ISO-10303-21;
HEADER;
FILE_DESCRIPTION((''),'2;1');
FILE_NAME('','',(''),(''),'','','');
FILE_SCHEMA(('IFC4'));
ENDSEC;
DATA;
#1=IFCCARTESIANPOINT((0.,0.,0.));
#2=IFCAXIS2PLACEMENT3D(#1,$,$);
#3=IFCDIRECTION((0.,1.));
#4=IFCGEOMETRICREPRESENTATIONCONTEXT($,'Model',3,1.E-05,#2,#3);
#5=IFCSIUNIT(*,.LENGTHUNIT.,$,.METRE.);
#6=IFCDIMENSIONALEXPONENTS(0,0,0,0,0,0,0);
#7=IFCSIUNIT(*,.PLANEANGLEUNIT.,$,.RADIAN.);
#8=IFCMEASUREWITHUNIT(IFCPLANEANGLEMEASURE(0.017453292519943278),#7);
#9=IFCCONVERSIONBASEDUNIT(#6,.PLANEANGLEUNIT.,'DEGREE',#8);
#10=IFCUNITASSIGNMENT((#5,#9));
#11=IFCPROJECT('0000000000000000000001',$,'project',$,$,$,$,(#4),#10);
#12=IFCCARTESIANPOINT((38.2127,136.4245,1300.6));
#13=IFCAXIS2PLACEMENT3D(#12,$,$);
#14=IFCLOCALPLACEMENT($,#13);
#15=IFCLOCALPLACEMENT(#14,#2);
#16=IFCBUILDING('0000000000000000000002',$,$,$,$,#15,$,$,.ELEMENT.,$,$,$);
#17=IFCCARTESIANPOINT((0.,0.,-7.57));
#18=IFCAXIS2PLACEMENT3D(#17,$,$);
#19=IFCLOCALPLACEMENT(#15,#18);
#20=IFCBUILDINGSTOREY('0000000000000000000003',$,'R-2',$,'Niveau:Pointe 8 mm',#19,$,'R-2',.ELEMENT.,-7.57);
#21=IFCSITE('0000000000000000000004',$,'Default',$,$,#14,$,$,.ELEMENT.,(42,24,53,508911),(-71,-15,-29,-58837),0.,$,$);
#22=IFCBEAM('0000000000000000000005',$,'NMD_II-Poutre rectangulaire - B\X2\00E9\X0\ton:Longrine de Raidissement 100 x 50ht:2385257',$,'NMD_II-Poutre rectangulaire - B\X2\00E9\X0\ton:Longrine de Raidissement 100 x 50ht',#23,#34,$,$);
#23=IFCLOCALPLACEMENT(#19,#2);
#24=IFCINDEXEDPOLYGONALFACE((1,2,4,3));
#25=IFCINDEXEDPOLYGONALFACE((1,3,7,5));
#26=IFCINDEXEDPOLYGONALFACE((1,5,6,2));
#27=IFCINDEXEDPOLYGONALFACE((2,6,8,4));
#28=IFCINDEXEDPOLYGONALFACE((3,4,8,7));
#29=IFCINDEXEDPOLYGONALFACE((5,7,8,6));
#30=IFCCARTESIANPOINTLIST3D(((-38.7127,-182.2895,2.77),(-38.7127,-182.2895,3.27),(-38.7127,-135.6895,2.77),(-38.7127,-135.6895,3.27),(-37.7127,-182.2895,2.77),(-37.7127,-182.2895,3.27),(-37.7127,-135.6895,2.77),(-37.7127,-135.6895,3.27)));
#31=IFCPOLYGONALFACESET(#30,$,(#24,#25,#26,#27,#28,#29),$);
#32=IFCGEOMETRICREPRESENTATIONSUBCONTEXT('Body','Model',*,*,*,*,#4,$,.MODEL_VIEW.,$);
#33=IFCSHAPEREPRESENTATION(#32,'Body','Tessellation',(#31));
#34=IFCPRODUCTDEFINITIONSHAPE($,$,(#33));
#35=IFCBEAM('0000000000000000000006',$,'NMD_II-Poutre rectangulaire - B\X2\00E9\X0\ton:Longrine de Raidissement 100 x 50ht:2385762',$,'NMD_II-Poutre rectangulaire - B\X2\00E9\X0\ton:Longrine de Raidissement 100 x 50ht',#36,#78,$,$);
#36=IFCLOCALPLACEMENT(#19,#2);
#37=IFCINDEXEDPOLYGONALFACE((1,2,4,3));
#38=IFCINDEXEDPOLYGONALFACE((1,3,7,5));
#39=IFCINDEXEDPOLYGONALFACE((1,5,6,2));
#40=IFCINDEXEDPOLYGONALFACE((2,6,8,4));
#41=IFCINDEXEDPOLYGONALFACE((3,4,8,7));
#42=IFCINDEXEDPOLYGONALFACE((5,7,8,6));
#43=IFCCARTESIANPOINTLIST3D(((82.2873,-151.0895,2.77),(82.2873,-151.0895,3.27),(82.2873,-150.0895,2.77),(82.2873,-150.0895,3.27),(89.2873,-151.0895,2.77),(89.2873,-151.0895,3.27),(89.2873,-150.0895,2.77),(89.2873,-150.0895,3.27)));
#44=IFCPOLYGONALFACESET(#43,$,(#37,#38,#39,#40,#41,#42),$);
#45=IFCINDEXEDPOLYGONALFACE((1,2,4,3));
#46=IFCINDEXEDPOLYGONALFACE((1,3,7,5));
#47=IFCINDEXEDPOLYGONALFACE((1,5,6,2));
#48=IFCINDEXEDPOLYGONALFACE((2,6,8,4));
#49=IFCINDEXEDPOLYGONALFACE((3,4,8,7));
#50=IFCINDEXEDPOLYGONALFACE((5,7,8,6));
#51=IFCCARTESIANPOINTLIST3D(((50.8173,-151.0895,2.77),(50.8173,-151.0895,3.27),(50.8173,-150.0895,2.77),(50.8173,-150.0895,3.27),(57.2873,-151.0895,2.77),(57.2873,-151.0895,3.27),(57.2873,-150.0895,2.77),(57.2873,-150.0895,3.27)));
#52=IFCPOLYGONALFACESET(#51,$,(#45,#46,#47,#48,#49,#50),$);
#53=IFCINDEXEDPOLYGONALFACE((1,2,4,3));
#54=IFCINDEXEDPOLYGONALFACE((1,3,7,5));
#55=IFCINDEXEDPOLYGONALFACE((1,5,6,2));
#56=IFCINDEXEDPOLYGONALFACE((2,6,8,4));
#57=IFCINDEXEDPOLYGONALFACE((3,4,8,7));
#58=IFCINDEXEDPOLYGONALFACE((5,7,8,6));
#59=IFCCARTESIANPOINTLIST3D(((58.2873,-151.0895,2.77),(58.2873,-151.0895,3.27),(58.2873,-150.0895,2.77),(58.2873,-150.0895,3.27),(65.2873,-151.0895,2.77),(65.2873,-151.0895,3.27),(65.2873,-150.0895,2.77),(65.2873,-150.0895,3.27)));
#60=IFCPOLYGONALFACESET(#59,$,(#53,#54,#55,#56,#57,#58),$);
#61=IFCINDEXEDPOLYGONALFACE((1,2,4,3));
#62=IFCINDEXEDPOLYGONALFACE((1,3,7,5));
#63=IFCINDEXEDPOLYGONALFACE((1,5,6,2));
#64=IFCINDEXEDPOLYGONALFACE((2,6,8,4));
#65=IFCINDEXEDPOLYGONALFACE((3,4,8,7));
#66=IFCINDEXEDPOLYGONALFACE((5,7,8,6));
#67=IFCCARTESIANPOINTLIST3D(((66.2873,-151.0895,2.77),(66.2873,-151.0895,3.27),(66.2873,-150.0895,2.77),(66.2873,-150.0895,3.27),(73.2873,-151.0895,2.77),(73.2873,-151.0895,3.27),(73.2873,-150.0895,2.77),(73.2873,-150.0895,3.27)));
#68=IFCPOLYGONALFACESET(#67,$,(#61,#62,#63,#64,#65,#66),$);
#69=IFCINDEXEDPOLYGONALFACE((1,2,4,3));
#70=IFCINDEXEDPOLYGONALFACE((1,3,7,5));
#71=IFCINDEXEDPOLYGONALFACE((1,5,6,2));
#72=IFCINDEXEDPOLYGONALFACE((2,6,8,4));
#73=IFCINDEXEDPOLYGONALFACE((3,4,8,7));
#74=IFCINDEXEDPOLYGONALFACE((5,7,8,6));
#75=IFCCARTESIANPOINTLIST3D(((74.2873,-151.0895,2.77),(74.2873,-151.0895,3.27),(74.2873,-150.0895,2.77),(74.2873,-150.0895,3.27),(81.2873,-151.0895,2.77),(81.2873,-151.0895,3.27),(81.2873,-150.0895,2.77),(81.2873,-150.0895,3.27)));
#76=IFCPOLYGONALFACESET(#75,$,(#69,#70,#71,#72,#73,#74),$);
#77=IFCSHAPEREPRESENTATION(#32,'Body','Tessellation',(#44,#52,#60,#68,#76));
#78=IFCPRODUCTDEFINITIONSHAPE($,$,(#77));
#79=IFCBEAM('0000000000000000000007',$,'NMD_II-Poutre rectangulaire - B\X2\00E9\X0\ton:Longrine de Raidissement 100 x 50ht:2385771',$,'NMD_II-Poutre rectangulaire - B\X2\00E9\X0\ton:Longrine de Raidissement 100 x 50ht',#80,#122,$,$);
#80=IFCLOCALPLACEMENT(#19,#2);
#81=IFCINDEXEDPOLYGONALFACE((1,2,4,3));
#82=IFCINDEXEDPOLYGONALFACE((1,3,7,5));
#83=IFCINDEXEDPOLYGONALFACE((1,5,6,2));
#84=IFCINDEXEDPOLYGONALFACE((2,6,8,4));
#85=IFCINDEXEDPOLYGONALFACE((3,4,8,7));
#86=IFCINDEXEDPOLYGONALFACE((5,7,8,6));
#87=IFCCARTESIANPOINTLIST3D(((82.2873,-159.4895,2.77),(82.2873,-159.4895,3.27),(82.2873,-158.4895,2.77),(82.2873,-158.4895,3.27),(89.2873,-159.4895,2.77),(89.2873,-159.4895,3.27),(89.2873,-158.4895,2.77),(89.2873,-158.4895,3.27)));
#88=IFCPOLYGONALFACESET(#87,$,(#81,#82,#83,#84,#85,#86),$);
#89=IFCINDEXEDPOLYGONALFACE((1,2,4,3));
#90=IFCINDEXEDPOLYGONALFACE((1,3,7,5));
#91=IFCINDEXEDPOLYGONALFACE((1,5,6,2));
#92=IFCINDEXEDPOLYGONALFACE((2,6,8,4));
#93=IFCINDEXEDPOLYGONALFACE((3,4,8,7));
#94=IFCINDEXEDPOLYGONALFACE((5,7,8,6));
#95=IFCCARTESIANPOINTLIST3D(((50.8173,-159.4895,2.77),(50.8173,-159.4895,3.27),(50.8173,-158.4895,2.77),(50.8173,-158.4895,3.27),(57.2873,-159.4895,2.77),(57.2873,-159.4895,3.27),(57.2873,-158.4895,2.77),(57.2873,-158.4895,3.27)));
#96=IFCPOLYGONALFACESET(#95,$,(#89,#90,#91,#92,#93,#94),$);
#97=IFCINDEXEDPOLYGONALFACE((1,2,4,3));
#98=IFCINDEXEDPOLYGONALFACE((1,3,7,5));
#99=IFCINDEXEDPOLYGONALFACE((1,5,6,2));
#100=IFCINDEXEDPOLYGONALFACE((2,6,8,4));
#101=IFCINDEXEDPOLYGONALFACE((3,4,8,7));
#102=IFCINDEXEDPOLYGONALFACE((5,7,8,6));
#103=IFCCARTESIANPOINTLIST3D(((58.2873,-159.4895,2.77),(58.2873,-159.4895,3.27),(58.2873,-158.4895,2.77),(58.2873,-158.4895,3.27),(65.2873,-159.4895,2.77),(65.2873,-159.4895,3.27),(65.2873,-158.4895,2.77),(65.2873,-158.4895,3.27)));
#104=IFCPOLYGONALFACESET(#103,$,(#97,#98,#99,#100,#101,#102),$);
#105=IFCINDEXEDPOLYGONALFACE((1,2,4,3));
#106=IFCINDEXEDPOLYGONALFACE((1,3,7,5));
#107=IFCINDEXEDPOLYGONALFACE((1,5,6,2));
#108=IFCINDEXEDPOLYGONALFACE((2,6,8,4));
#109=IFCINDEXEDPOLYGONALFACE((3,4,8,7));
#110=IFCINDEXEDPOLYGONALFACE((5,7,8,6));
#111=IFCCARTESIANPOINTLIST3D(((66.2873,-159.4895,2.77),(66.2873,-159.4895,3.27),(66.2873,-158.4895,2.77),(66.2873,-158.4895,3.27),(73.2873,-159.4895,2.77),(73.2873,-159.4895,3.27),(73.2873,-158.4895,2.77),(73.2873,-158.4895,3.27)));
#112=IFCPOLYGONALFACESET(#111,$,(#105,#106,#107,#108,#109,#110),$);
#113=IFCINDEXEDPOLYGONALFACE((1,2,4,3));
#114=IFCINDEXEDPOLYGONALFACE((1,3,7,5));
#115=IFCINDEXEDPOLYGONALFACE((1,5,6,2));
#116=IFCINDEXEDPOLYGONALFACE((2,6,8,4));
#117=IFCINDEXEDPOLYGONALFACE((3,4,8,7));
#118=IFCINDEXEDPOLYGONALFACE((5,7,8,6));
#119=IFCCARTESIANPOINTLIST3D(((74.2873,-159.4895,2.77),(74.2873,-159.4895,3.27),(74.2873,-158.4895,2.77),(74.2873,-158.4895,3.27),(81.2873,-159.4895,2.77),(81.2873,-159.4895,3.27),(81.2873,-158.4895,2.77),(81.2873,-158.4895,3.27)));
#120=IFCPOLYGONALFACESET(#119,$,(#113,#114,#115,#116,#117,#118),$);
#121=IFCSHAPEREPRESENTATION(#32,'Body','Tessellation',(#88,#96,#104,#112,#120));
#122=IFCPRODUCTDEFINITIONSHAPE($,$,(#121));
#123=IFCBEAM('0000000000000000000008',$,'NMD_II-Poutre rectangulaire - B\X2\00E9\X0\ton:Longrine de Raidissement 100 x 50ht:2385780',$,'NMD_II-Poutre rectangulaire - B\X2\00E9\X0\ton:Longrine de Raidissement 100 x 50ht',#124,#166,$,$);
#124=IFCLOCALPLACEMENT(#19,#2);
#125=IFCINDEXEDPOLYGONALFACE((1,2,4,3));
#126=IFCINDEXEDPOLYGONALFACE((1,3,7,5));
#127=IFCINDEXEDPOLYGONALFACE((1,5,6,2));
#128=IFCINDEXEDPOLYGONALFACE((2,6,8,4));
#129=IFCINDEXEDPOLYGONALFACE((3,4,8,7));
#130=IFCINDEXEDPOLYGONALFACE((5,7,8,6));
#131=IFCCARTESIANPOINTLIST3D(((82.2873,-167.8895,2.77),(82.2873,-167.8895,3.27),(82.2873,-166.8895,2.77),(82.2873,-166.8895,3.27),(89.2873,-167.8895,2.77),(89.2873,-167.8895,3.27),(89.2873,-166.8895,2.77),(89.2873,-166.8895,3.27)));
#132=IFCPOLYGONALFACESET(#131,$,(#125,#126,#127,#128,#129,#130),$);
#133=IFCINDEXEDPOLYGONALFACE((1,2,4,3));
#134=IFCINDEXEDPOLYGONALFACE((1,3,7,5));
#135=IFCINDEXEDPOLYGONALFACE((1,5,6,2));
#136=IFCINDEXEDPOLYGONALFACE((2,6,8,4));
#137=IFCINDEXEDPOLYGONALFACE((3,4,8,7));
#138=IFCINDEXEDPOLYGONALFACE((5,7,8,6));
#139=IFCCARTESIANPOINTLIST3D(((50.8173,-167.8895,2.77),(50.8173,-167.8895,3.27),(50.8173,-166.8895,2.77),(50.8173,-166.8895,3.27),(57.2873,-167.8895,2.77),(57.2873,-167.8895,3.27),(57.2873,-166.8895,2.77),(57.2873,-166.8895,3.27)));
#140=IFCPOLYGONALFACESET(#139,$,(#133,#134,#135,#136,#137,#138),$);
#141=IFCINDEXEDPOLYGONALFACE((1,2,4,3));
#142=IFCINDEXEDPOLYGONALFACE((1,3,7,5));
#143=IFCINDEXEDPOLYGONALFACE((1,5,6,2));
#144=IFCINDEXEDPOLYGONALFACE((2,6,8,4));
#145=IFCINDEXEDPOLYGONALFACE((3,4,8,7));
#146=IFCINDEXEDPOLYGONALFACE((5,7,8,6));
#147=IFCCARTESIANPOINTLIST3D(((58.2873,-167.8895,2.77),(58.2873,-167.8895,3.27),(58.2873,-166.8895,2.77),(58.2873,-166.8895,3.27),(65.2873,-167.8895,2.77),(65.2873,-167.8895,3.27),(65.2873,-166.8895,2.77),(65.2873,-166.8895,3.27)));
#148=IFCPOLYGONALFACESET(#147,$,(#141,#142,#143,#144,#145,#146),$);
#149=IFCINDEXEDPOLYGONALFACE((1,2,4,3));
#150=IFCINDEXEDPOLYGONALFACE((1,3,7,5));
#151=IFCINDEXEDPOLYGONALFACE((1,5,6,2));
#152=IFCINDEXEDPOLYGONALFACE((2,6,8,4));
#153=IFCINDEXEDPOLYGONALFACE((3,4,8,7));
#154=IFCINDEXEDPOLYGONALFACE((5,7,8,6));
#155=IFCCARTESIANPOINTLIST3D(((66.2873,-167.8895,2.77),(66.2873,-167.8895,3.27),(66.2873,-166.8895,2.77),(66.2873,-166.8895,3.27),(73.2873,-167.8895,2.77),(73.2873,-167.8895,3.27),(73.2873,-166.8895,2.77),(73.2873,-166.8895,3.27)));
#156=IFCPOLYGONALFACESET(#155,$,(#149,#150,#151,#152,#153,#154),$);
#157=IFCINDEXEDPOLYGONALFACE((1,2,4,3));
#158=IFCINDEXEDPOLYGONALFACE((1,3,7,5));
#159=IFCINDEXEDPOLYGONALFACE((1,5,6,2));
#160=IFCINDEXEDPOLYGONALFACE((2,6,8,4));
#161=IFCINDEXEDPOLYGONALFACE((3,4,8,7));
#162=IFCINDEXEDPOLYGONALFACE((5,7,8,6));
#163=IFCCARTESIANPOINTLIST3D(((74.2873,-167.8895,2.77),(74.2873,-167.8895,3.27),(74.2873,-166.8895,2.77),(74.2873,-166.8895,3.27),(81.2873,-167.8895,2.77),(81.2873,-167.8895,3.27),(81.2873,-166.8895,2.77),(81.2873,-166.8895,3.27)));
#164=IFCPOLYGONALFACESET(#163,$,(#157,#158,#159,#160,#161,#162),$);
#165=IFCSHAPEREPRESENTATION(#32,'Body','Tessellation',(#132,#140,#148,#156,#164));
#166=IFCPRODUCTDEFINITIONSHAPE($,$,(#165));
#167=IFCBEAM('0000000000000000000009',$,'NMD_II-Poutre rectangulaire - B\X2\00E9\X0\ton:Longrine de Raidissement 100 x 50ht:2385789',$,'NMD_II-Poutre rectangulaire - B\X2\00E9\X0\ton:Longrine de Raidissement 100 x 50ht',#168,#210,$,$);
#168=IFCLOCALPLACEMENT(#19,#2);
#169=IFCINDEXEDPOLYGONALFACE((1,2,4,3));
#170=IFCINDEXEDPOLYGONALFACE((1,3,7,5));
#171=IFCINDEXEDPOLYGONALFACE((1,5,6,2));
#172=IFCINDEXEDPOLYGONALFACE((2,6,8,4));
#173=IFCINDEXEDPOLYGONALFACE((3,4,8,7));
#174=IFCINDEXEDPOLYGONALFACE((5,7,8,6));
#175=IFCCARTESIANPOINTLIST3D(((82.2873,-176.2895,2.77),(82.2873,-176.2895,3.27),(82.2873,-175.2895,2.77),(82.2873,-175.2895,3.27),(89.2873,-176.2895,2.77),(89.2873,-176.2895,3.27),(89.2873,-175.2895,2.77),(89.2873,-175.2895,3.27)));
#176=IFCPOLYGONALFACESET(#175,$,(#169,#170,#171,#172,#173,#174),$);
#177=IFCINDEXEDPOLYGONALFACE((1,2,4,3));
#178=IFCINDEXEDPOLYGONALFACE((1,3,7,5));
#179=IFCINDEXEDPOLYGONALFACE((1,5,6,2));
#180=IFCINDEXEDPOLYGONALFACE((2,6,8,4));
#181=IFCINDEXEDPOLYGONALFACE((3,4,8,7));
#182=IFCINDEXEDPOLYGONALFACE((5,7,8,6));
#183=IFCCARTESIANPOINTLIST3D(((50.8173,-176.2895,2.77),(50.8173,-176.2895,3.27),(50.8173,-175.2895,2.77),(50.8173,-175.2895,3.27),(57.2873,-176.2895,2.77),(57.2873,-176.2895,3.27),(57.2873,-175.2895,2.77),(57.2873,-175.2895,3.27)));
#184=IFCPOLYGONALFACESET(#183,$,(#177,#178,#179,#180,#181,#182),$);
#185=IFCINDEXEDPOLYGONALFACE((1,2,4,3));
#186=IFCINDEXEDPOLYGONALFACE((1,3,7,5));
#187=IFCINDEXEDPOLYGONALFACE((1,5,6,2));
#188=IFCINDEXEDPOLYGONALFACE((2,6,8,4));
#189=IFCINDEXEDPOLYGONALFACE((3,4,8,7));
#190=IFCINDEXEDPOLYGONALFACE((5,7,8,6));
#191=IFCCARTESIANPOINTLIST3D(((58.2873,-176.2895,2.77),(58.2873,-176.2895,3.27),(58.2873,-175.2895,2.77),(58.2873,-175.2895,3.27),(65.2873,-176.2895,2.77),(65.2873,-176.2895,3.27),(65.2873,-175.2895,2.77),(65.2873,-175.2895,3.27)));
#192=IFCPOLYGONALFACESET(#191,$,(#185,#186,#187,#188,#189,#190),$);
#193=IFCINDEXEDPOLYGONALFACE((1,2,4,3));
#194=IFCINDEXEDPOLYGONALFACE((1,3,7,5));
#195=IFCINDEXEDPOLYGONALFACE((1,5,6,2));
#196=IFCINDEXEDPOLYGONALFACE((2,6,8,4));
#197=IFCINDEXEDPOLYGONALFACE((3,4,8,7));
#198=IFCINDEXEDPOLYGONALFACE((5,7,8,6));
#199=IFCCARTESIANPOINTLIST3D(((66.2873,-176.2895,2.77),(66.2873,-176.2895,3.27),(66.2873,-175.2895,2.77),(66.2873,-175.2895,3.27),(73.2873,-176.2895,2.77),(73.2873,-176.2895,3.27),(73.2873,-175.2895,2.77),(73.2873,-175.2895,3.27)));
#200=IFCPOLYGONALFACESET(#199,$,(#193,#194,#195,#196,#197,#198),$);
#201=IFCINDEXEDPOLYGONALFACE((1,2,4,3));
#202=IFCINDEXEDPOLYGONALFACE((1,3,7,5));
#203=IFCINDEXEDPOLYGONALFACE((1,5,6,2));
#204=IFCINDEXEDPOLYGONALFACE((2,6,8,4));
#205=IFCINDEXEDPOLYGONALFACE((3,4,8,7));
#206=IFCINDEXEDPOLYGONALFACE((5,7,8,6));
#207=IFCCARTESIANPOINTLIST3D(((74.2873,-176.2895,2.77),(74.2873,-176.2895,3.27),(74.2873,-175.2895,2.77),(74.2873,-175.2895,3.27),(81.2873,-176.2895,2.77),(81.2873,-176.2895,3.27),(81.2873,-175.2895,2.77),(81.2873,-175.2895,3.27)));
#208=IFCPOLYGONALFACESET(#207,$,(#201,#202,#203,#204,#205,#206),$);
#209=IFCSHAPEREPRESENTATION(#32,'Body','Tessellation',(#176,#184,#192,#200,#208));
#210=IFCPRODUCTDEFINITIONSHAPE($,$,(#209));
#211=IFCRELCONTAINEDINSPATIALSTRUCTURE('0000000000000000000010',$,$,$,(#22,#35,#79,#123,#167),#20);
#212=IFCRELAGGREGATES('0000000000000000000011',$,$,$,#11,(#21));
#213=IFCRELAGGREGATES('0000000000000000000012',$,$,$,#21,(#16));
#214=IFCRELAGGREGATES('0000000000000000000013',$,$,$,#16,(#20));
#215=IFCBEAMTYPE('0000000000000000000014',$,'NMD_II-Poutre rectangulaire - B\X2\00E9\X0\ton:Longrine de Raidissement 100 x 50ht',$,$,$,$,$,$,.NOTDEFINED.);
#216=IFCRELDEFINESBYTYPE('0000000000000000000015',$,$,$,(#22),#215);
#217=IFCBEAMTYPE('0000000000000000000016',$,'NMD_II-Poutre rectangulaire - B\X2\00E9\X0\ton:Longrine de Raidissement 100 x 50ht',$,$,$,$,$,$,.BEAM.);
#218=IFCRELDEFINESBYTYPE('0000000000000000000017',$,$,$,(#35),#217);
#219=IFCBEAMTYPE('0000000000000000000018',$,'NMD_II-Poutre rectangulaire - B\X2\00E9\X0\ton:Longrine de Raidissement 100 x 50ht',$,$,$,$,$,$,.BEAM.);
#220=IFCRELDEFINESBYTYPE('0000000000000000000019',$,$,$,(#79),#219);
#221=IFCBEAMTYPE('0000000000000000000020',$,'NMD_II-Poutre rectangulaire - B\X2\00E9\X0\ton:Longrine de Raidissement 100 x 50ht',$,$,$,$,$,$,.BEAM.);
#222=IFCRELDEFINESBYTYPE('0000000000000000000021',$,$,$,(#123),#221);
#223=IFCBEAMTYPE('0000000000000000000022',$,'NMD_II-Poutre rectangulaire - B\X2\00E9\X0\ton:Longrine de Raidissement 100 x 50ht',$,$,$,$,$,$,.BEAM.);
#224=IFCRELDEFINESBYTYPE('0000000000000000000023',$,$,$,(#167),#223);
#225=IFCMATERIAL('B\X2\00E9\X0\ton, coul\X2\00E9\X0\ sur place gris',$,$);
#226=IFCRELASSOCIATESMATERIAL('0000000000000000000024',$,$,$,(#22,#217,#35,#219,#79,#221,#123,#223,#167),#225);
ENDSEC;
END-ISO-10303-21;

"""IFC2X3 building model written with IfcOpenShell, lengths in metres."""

from ifc_helpers import new_model, entity, si_unit, converted_unit, direction, frame, frame_2d, origin, place, context, subcontext, project, spatial, rectangle, extrude, source, transform, mapped, material, type_object, type_shapes, element, save


model = new_model("IFC2X3")

# Units and contexts
model_context = context("Model", 3, precision=1e-05, world=origin(), true_north=direction((0.0, 1.0)))
body_context = subcontext(model_context, "Body", "Model", "MODEL_VIEW")
ifc_project = project(units=[si_unit("LENGTHUNIT", "METRE"), converted_unit("PLANEANGLEUNIT", "DEGREE", entity("IfcPlaneAngleMeasure", 0.017453292519943278), si_unit("PLANEANGLEUNIT", "RADIAN"), dimensions=[0, 0, 0, 0, 0, 0, 0])], contexts=[model_context])

# Site, building, storey
site_placement = place(None, frame((38.2127, 136.4245, 1300.6)))
site = spatial("IfcSite", under=ifc_project, at=site_placement, Name="Default", CompositionType="ELEMENT", RefLatitude=(42, 24, 53, 508911), RefLongitude=(-71, -15, -29, -58837), RefElevation=0.0)
building_placement = place(site_placement, origin())
building = spatial("IfcBuilding", under=site, at=building_placement, CompositionType="ELEMENT")
storey_placement = place(building_placement, frame((0.0, 0.0, -7.57)))
storey = spatial("IfcBuildingStorey", under=building, at=storey_placement, Name="R-2", ObjectType="Niveau:Pointe 8 mm", LongName="R-2", CompositionType="ELEMENT", Elevation=-7.57)

# Beams
ifc_material_1 = material(Name="Béton, coulé sur place gris")
beam_type_1 = type_object("IfcBeamType", Name="NMD_II-Poutre rectangulaire - Béton:Longrine de Raidissement 100 x 50ht", PredefinedType="NOTDEFINED")
beam_1_placement = place(storey_placement, frame((-38.2127, -136.1895, 3.27), z_axis=(0.0, 0.0, 1.0), x_axis=(0.0, -1.0, 0.0)))
element("IfcBeam", 1, at=beam_1_placement, inside=storey, type_object=beam_type_1, material=ifc_material_1, Name="NMD_II-Poutre rectangulaire - Béton:Longrine de Raidissement 100 x 50ht:2385257", ObjectType="NMD_II-Poutre rectangulaire - Béton:Longrine de Raidissement 100 x 50ht", context=body_context, shape_type="SweptSolid", body=[
    extrude(rectangle(XDim=0.5, YDim=1.0, at=frame_2d((0.0, 0.0), x_axis=(1.0, 0.0))), frame((-0.5, 0.0, -0.25), z_axis=(1.0, 0.0, 0.0), x_axis=(0.0, 0.0, -1.0)), (0.0, 0.0, 1.0), 46.6),
])
beam_type_2 = type_object("IfcBeamType", Name="NMD_II-Poutre rectangulaire - Béton:Longrine de Raidissement 100 x 50ht", PredefinedType="BEAM", material=ifc_material_1)
shared_shape_1 = source(origin(), body_context, "Body", "SweptSolid", [
    extrude(rectangle(XDim=0.5, YDim=1.0, at=frame_2d((0.0, 0.0), x_axis=(1.0, 0.0))), frame((89.2873, -150.5895, -4.55), z_axis=(-1.0, 0.0, 0.0), x_axis=(0.0, 0.0, -1.0)), (0.0, 0.0, 1.0), 7.0),
    extrude(rectangle(XDim=0.5, YDim=1.0, at=frame_2d((0.0, 0.0), x_axis=(1.0, 0.0))), frame((57.2873, -150.5895, -4.55), z_axis=(-1.0, 0.0, 0.0), x_axis=(0.0, 0.0, -1.0)), (0.0, 0.0, 1.0), 6.47),
    extrude(rectangle(XDim=0.5, YDim=1.0, at=frame_2d((0.0, 0.0), x_axis=(1.0, 0.0))), frame((65.2873, -150.5895, -4.55), z_axis=(-1.0, 0.0, 0.0), x_axis=(0.0, 0.0, -1.0)), (0.0, 0.0, 1.0), 7.0),
    extrude(rectangle(XDim=0.5, YDim=1.0, at=frame_2d((0.0, 0.0), x_axis=(1.0, 0.0))), frame((73.2873, -150.5895, -4.55), z_axis=(-1.0, 0.0, 0.0), x_axis=(0.0, 0.0, -1.0)), (0.0, 0.0, 1.0), 7.0),
    extrude(rectangle(XDim=0.5, YDim=1.0, at=frame_2d((0.0, 0.0), x_axis=(1.0, 0.0))), frame((81.2873, -150.5895, -4.55), z_axis=(-1.0, 0.0, 0.0), x_axis=(0.0, 0.0, -1.0)), (0.0, 0.0, 1.0), 7.0),
])
type_shapes(beam_type_2, [shared_shape_1])
beam_2_placement = place(storey_placement, frame((0.0, 0.0, 7.57)))
element("IfcBeam", 2, at=beam_2_placement, inside=storey, type_object=beam_type_2, material=ifc_material_1, Name="NMD_II-Poutre rectangulaire - Béton:Longrine de Raidissement 100 x 50ht:2385762", ObjectType="NMD_II-Poutre rectangulaire - Béton:Longrine de Raidissement 100 x 50ht", context=body_context, shape_type="MappedRepresentation", body=[
    mapped(shared_shape_1, transform((0.0, 0.0, 0.0), scale=1.0)),
])
beam_type_3 = type_object("IfcBeamType", Name="NMD_II-Poutre rectangulaire - Béton:Longrine de Raidissement 100 x 50ht", PredefinedType="BEAM", material=ifc_material_1)
shared_shape_2 = source(origin(), body_context, "Body", "SweptSolid", [
    extrude(rectangle(XDim=0.5, YDim=1.0, at=frame_2d((0.0, 0.0), x_axis=(1.0, 0.0))), frame((89.2873, -158.9895, -4.55), z_axis=(-1.0, 0.0, 0.0), x_axis=(0.0, 0.0, -1.0)), (0.0, 0.0, 1.0), 7.0),
    extrude(rectangle(XDim=0.5, YDim=1.0, at=frame_2d((0.0, 0.0), x_axis=(1.0, 0.0))), frame((57.2873, -158.9895, -4.55), z_axis=(-1.0, 0.0, 0.0), x_axis=(0.0, 0.0, -1.0)), (0.0, 0.0, 1.0), 6.47),
    extrude(rectangle(XDim=0.5, YDim=1.0, at=frame_2d((0.0, 0.0), x_axis=(1.0, 0.0))), frame((65.2873, -158.9895, -4.55), z_axis=(-1.0, 0.0, 0.0), x_axis=(0.0, 0.0, -1.0)), (0.0, 0.0, 1.0), 7.0),
    extrude(rectangle(XDim=0.5, YDim=1.0, at=frame_2d((0.0, 0.0), x_axis=(1.0, 0.0))), frame((73.2873, -158.9895, -4.55), z_axis=(-1.0, 0.0, 0.0), x_axis=(0.0, 0.0, -1.0)), (0.0, 0.0, 1.0), 7.0),
    extrude(rectangle(XDim=0.5, YDim=1.0, at=frame_2d((0.0, 0.0), x_axis=(1.0, 0.0))), frame((81.2873, -158.9895, -4.55), z_axis=(-1.0, 0.0, 0.0), x_axis=(0.0, 0.0, -1.0)), (0.0, 0.0, 1.0), 7.0),
])
type_shapes(beam_type_3, [shared_shape_2])
beam_3_placement = place(storey_placement, frame((0.0, 0.0, 7.57)))
element("IfcBeam", 3, at=beam_3_placement, inside=storey, type_object=beam_type_3, material=ifc_material_1, Name="NMD_II-Poutre rectangulaire - Béton:Longrine de Raidissement 100 x 50ht:2385771", ObjectType="NMD_II-Poutre rectangulaire - Béton:Longrine de Raidissement 100 x 50ht", context=body_context, shape_type="MappedRepresentation", body=[
    mapped(shared_shape_2, transform((0.0, 0.0, 0.0), scale=1.0)),
])
beam_type_4 = type_object("IfcBeamType", Name="NMD_II-Poutre rectangulaire - Béton:Longrine de Raidissement 100 x 50ht", PredefinedType="BEAM", material=ifc_material_1)
shared_shape_3 = source(origin(), body_context, "Body", "SweptSolid", [
    extrude(rectangle(XDim=0.5, YDim=1.0, at=frame_2d((0.0, 0.0), x_axis=(1.0, 0.0))), frame((89.2873, -167.3895, -4.55), z_axis=(-1.0, 0.0, 0.0), x_axis=(0.0, 0.0, -1.0)), (0.0, 0.0, 1.0), 7.0),
    extrude(rectangle(XDim=0.5, YDim=1.0, at=frame_2d((0.0, 0.0), x_axis=(1.0, 0.0))), frame((57.2873, -167.3895, -4.55), z_axis=(-1.0, 0.0, 0.0), x_axis=(0.0, 0.0, -1.0)), (0.0, 0.0, 1.0), 6.47),
    extrude(rectangle(XDim=0.5, YDim=1.0, at=frame_2d((0.0, 0.0), x_axis=(1.0, 0.0))), frame((65.2873, -167.3895, -4.55), z_axis=(-1.0, 0.0, 0.0), x_axis=(0.0, 0.0, -1.0)), (0.0, 0.0, 1.0), 7.0),
    extrude(rectangle(XDim=0.5, YDim=1.0, at=frame_2d((0.0, 0.0), x_axis=(1.0, 0.0))), frame((73.2873, -167.3895, -4.55), z_axis=(-1.0, 0.0, 0.0), x_axis=(0.0, 0.0, -1.0)), (0.0, 0.0, 1.0), 7.0),
    extrude(rectangle(XDim=0.5, YDim=1.0, at=frame_2d((0.0, 0.0), x_axis=(1.0, 0.0))), frame((81.2873, -167.3895, -4.55), z_axis=(-1.0, 0.0, 0.0), x_axis=(0.0, 0.0, -1.0)), (0.0, 0.0, 1.0), 7.0),
])
type_shapes(beam_type_4, [shared_shape_3])
beam_4_placement = place(storey_placement, frame((0.0, 0.0, 7.57)))
element("IfcBeam", 4, at=beam_4_placement, inside=storey, type_object=beam_type_4, material=ifc_material_1, Name="NMD_II-Poutre rectangulaire - Béton:Longrine de Raidissement 100 x 50ht:2385780", ObjectType="NMD_II-Poutre rectangulaire - Béton:Longrine de Raidissement 100 x 50ht", context=body_context, shape_type="MappedRepresentation", body=[
    mapped(shared_shape_3, transform((0.0, 0.0, 0.0), scale=1.0)),
])
beam_type_5 = type_object("IfcBeamType", Name="NMD_II-Poutre rectangulaire - Béton:Longrine de Raidissement 100 x 50ht", PredefinedType="BEAM", material=ifc_material_1)
shared_shape_4 = source(origin(), body_context, "Body", "SweptSolid", [
    extrude(rectangle(XDim=0.5, YDim=1.0, at=frame_2d((0.0, 0.0), x_axis=(1.0, 0.0))), frame((89.2873, -175.7895, -4.55), z_axis=(-1.0, 0.0, 0.0), x_axis=(0.0, 0.0, -1.0)), (0.0, 0.0, 1.0), 7.0),
    extrude(rectangle(XDim=0.5, YDim=1.0, at=frame_2d((0.0, 0.0), x_axis=(1.0, 0.0))), frame((57.2873, -175.7895, -4.55), z_axis=(-1.0, 0.0, 0.0), x_axis=(0.0, 0.0, -1.0)), (0.0, 0.0, 1.0), 6.47),
    extrude(rectangle(XDim=0.5, YDim=1.0, at=frame_2d((0.0, 0.0), x_axis=(1.0, 0.0))), frame((65.2873, -175.7895, -4.55), z_axis=(-1.0, 0.0, 0.0), x_axis=(0.0, 0.0, -1.0)), (0.0, 0.0, 1.0), 7.0),
    extrude(rectangle(XDim=0.5, YDim=1.0, at=frame_2d((0.0, 0.0), x_axis=(1.0, 0.0))), frame((73.2873, -175.7895, -4.55), z_axis=(-1.0, 0.0, 0.0), x_axis=(0.0, 0.0, -1.0)), (0.0, 0.0, 1.0), 7.0),
    extrude(rectangle(XDim=0.5, YDim=1.0, at=frame_2d((0.0, 0.0), x_axis=(1.0, 0.0))), frame((81.2873, -175.7895, -4.55), z_axis=(-1.0, 0.0, 0.0), x_axis=(0.0, 0.0, -1.0)), (0.0, 0.0, 1.0), 7.0),
])
type_shapes(beam_type_5, [shared_shape_4])
beam_5_placement = place(storey_placement, frame((0.0, 0.0, 7.57)))
element("IfcBeam", 5, at=beam_5_placement, inside=storey, type_object=beam_type_5, material=ifc_material_1, Name="NMD_II-Poutre rectangulaire - Béton:Longrine de Raidissement 100 x 50ht:2385789", ObjectType="NMD_II-Poutre rectangulaire - Béton:Longrine de Raidissement 100 x 50ht", context=body_context, shape_type="MappedRepresentation", body=[
    mapped(shared_shape_4, transform((0.0, 0.0, 0.0), scale=1.0)),
])

save(model, "model.ifc")
